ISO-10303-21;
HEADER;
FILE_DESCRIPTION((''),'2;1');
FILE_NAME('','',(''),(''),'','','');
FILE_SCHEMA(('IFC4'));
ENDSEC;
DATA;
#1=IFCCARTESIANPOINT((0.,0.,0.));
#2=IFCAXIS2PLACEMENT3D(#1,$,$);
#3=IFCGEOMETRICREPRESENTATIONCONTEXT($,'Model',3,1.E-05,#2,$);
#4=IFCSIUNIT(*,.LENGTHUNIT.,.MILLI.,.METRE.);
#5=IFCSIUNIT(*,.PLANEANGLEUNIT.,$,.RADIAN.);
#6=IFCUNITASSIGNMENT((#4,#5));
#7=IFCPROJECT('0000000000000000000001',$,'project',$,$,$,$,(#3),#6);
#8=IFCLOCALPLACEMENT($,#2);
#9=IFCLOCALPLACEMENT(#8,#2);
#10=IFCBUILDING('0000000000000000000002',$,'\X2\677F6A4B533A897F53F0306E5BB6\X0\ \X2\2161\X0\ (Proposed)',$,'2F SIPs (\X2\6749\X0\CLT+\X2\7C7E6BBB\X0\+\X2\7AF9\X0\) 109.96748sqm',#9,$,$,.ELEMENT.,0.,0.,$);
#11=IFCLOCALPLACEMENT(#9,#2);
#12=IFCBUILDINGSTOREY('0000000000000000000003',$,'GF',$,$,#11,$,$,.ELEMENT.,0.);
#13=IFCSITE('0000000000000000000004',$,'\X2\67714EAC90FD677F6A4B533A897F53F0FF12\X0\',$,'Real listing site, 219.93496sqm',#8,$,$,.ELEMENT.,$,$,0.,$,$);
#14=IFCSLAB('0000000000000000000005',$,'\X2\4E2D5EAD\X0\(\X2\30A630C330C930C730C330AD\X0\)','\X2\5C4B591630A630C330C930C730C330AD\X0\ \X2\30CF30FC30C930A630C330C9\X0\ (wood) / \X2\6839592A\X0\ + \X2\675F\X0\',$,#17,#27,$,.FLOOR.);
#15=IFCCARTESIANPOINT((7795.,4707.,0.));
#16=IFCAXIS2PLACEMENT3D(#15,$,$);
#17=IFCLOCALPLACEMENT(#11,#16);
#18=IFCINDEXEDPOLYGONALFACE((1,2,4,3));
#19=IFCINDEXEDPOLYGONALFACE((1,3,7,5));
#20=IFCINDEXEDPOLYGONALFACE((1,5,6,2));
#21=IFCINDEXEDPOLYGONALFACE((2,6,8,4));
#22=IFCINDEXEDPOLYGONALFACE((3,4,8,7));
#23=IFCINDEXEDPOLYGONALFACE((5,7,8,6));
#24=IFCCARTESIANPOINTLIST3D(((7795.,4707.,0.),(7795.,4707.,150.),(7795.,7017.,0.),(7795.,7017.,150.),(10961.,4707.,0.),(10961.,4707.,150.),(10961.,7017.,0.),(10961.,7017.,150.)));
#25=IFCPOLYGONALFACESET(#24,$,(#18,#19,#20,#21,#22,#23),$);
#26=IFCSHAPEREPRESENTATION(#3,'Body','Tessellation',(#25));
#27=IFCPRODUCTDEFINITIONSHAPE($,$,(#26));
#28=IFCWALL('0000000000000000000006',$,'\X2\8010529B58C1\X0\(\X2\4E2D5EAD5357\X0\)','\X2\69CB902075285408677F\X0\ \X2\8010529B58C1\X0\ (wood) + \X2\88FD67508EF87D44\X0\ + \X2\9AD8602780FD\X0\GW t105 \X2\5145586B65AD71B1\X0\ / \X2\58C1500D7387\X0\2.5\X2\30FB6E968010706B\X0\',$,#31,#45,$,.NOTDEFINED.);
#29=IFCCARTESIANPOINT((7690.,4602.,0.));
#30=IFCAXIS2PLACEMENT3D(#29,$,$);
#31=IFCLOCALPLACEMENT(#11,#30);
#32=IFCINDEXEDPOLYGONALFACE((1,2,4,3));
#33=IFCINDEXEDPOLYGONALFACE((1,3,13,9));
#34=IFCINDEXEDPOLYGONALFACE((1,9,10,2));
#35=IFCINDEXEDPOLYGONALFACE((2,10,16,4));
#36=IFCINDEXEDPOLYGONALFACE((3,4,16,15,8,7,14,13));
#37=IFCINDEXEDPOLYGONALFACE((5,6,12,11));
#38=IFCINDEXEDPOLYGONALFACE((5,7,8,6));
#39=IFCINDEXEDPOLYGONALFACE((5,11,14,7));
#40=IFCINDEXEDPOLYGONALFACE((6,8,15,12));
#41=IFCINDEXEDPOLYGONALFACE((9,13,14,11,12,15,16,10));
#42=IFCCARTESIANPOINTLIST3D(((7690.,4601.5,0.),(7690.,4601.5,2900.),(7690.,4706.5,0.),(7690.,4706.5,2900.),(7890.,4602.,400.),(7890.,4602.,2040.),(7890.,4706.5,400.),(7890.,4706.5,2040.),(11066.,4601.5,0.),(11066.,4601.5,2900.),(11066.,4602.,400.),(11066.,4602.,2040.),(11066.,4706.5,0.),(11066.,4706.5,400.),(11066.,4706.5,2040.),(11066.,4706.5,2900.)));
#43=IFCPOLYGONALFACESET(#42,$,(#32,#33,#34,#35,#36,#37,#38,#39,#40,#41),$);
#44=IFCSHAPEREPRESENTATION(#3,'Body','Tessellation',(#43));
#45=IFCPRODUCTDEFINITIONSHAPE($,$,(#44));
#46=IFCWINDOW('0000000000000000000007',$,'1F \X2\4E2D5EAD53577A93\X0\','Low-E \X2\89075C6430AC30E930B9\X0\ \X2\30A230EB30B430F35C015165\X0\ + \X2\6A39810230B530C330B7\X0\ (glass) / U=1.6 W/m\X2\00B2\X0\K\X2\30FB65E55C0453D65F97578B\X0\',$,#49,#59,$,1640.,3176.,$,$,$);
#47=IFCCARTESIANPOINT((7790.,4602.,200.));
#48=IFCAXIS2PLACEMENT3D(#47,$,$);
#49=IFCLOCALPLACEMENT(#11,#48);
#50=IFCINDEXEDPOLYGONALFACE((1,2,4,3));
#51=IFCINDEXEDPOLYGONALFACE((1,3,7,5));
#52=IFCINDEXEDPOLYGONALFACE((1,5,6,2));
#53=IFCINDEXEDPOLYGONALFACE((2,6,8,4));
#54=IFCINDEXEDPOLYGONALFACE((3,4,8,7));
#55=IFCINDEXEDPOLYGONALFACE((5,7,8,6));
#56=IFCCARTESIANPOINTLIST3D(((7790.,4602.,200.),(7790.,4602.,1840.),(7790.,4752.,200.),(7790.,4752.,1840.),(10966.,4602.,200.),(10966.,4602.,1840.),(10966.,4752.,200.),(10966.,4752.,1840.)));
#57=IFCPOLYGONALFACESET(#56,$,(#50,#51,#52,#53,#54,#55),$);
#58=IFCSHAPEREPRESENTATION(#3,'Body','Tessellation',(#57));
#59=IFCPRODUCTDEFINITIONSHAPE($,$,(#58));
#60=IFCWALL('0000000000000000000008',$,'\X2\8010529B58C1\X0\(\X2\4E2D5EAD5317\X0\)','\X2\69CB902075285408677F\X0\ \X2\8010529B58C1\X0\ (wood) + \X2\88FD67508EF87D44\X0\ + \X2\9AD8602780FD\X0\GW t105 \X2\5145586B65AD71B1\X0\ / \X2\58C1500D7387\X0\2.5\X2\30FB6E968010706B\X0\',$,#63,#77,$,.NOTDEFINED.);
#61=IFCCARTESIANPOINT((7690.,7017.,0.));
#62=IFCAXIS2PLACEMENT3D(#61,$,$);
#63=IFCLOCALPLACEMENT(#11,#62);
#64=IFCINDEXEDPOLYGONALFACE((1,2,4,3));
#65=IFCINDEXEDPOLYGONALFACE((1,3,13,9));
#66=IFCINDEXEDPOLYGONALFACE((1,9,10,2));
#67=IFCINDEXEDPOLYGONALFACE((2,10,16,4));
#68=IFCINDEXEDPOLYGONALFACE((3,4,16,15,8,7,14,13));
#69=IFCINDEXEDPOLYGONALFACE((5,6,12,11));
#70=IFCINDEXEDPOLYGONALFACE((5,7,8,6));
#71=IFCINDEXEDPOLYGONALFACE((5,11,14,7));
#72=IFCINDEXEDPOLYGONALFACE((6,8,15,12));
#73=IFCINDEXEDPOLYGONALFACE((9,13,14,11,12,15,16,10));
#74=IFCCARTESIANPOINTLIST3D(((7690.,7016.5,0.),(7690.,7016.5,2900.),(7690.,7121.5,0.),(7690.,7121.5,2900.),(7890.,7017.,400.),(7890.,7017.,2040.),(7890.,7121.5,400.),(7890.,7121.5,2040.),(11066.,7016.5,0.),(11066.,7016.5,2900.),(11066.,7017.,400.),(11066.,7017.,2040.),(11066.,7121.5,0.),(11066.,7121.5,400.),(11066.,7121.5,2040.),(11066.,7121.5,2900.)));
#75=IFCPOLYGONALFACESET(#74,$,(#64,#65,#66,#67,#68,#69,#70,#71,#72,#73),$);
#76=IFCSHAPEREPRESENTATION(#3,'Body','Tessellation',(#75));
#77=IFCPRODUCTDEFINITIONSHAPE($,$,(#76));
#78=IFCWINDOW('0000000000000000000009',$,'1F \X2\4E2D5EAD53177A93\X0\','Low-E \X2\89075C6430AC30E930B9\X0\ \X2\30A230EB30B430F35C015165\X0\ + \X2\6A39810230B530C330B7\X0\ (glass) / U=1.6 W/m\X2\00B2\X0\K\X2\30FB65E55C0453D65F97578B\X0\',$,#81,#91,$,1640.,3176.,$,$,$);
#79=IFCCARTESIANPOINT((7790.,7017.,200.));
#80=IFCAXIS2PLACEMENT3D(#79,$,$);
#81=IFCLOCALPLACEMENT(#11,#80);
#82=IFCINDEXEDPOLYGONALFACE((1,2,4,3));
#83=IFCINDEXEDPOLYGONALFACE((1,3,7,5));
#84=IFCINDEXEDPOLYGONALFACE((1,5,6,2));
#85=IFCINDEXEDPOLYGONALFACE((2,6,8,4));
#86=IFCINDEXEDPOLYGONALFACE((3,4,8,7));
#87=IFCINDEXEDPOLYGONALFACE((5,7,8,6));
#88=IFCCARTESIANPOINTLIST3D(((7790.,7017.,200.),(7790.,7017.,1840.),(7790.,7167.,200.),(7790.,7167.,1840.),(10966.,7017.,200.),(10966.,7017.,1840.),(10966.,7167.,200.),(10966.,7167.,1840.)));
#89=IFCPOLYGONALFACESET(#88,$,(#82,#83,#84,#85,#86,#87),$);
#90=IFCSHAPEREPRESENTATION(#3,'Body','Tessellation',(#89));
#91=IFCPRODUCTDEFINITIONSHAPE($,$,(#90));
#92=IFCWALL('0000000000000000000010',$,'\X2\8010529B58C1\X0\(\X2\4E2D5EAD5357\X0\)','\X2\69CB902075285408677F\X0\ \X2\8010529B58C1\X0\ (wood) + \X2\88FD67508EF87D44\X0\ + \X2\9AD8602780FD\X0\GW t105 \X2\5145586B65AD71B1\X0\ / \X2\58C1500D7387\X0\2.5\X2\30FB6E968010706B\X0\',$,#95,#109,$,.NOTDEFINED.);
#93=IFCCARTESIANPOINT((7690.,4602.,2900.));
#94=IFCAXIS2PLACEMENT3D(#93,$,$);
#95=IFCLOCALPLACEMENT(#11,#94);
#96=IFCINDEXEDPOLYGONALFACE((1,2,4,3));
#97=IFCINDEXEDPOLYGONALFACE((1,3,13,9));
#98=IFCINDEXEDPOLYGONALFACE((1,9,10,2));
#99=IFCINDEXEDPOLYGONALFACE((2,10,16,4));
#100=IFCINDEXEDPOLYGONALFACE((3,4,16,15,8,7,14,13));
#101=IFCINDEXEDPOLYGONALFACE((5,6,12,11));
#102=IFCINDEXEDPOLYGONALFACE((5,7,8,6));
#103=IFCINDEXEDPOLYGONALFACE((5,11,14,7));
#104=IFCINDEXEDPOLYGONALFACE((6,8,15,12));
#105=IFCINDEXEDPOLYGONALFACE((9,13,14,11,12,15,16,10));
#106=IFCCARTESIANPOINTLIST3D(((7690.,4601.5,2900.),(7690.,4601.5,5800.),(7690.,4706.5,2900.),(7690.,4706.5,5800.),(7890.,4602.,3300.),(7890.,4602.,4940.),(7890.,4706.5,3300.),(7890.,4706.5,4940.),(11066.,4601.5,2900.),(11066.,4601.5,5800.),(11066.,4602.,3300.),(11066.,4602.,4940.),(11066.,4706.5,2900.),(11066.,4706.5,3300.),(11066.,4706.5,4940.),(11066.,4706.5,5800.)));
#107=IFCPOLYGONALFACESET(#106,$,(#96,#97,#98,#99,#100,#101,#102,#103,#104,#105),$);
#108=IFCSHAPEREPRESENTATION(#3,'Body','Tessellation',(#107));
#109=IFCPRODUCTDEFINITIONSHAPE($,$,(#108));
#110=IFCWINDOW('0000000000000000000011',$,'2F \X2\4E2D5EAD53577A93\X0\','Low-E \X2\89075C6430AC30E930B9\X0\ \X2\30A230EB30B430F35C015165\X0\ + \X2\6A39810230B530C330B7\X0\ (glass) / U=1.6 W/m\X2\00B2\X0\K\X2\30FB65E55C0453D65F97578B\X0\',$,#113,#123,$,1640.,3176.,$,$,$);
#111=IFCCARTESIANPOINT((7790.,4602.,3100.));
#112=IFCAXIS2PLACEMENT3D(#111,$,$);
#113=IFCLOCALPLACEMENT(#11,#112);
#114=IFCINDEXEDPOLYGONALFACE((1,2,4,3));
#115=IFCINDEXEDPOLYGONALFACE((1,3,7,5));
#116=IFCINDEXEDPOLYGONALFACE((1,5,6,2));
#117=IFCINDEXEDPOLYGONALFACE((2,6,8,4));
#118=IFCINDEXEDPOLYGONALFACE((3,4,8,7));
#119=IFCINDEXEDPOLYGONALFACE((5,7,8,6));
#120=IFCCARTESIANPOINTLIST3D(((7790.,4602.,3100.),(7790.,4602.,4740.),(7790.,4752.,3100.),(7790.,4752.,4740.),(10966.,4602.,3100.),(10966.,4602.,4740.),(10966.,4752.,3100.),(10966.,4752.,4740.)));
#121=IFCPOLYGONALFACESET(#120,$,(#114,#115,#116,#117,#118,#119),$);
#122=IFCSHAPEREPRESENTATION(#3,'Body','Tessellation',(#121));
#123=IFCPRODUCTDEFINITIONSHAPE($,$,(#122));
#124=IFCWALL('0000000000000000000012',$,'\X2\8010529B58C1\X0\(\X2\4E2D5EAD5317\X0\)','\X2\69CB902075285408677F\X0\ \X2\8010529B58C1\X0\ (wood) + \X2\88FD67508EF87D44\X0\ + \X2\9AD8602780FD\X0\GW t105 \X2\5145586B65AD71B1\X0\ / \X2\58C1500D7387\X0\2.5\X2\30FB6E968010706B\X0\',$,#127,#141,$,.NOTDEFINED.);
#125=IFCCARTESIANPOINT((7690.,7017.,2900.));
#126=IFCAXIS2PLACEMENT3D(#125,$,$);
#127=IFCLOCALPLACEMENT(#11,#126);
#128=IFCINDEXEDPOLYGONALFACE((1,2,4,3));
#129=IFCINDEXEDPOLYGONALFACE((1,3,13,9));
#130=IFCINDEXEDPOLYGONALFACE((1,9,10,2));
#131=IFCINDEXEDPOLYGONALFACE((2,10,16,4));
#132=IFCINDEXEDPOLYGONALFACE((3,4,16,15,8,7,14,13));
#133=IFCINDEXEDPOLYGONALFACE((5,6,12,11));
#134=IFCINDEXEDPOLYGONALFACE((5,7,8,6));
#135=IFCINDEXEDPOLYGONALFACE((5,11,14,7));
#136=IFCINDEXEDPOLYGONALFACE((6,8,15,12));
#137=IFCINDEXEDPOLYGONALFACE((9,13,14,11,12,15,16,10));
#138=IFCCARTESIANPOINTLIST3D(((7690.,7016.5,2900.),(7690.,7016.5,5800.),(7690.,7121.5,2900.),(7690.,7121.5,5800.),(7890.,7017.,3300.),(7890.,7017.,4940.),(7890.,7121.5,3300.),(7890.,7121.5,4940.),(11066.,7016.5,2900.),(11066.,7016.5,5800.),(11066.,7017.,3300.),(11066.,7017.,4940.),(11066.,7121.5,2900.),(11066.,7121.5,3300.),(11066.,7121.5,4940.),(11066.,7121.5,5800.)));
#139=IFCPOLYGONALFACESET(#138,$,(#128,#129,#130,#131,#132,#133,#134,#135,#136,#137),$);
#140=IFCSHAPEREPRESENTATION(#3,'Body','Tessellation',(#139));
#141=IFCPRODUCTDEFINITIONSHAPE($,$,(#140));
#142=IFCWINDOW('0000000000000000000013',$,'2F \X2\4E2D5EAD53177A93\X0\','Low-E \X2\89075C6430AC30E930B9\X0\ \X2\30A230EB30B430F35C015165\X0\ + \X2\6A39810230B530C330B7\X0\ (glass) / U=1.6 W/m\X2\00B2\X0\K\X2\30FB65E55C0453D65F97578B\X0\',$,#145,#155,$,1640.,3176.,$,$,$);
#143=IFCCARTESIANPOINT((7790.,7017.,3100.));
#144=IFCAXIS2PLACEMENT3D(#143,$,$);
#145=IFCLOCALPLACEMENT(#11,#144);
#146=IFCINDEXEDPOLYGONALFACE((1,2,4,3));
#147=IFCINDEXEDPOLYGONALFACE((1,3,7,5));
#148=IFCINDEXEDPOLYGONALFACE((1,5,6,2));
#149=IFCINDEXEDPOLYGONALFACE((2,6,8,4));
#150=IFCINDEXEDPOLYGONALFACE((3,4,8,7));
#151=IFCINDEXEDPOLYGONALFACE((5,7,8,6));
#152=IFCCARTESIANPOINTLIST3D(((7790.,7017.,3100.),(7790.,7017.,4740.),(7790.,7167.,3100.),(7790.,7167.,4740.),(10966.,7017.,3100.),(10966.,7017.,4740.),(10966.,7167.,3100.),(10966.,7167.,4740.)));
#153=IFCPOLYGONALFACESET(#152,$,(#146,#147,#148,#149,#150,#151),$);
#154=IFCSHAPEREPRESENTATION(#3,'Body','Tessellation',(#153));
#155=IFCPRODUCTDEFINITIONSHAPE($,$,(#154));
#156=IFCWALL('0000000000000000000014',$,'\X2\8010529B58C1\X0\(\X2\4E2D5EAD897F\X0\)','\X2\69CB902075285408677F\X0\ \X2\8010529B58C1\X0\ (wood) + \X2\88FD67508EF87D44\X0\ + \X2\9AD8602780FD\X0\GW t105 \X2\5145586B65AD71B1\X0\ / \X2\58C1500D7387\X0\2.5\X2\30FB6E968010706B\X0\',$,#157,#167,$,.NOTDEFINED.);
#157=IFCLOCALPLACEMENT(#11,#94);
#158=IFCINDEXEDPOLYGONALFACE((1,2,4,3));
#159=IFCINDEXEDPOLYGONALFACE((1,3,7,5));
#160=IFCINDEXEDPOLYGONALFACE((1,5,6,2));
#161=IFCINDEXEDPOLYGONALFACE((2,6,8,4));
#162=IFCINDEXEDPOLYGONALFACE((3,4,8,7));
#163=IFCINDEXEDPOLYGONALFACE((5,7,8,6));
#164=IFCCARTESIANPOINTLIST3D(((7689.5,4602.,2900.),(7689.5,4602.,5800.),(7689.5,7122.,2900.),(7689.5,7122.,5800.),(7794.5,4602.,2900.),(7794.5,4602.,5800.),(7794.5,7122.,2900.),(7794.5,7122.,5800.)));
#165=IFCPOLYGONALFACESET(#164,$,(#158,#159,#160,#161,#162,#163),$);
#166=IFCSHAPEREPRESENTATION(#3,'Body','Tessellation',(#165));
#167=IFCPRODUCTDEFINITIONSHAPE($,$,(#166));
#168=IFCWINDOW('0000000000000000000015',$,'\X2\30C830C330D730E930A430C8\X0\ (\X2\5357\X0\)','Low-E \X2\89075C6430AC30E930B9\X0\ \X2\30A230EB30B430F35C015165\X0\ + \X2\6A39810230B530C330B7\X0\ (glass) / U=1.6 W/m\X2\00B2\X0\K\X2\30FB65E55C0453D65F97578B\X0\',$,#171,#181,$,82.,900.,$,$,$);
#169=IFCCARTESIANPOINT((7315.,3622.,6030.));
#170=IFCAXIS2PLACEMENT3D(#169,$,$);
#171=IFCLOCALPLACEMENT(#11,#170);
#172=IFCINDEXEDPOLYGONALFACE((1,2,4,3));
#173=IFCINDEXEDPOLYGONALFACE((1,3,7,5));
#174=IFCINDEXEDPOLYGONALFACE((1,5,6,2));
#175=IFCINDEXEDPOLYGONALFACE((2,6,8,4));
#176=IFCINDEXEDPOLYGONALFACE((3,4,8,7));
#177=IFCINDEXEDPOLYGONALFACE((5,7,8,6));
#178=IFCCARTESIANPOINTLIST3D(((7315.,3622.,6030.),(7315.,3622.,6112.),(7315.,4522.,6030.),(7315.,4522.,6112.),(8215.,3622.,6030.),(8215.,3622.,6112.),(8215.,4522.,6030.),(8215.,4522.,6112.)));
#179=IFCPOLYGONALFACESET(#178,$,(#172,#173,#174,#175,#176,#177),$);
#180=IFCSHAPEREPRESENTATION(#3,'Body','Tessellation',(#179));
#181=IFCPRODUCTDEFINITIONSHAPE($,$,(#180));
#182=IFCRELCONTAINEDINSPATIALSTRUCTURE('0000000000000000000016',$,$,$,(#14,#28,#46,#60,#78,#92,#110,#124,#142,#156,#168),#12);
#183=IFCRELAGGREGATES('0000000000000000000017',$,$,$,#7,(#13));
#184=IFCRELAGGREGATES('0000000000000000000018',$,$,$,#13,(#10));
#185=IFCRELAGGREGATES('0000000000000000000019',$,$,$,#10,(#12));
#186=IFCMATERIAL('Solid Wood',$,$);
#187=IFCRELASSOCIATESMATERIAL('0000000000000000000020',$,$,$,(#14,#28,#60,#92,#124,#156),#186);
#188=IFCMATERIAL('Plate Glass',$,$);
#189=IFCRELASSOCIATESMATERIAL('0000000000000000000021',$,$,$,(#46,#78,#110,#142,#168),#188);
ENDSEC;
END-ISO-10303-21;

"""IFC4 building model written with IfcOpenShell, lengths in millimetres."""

from ifc_helpers import new_model, si_unit, frame, frame_2d, origin, place, context, project, spatial, rectangle, extrude, material, element, fill, save


model = new_model("IFC4")

# Units and contexts
model_context = context("Model", 3, precision=1e-05, world=origin())
ifc_project = project(units=[si_unit("LENGTHUNIT", "METRE", prefix="MILLI"), si_unit("PLANEANGLEUNIT", "RADIAN")], contexts=[model_context])

# Site, building, storey
site_placement = place(None, origin())
site = spatial("IfcSite", under=ifc_project, at=site_placement, Name="東京都板橋区西台２", ObjectType="Real listing site, 219.93496sqm", CompositionType="ELEMENT", RefElevation=0.0)
building_placement = place(site_placement, origin())
building = spatial("IfcBuilding", under=site, at=building_placement, Name="板橋区西台の家 Ⅱ (Proposed)", ObjectType="2F SIPs (杉CLT+籾殻+竹) 109.96748sqm", CompositionType="ELEMENT", ElevationOfRefHeight=0.0, ElevationOfTerrain=0.0)
storey_placement = place(building_placement, origin())
storey = spatial("IfcBuildingStorey", under=building, at=storey_placement, Name="GF", CompositionType="ELEMENT", Elevation=0.0)

# Slab
ifc_material_1 = material(Name="Solid Wood")
slab_placement = place(storey_placement, frame((7795.0, 4707.0, 0.0)))
element("IfcSlab", 1, at=slab_placement, inside=storey, material=ifc_material_1, Name="中庭(ウッドデッキ)", Description="屋外ウッドデッキ ハードウッド (wood) / 根太 + 束", PredefinedType="FLOOR", context=model_context, shape_type="SweptSolid", body=[
    extrude(rectangle(XDim=3166.0, YDim=2310.0, at=frame_2d((1583.0, 1155.0))), frame((7795.0, 4707.0, 0.0)), (0.0, 0.0, 1.0), 150.0),
])

# Walls, openings, windows
wall_1_placement = place(storey_placement, frame((7690.0, 4602.0, 0.0)))
wall_1 = element("IfcWall", 2, at=wall_1_placement, inside=storey, material=ifc_material_1, Name="耐力壁(中庭南)", Description="構造用合板 耐力壁 (wood) + 製材軸組 + 高性能GW t105 充填断熱 / 壁倍率2.5・準耐火", PredefinedType="NOTDEFINED", context=model_context, shape_type="SweptSolid", body=[
    extrude(rectangle(XDim=3376.0, YDim=105.0, at=frame_2d((1688.0, 52.0))), frame((7690.0, 4602.0, 0.0)), (0.0, 0.0, 1.0), 2900.0),
])
opening_1_placement = place(storey_placement, frame((7790.0, 4602.0, 200.0)))
opening_1 = element("IfcOpeningElement", 3, at=opening_1_placement, cuts=wall_1, PredefinedType="NOTDEFINED", context=model_context, shape_type="SweptSolid", body=[
    extrude(rectangle(XDim=3176.0, YDim=150.0, at=frame_2d((1588.0, 75.0))), frame((7790.0, 4602.0, 200.0)), (0.0, 0.0, 1.0), 1640.0),
])
ifc_material_2 = material(Name="Plate Glass")
window_1_placement = place(storey_placement, frame((7790.0, 4602.0, 200.0)))
window_1 = element("IfcWindow", 4, at=window_1_placement, inside=storey, material=ifc_material_2, Name="1F 中庭南窓", Description="Low-E 複層ガラス アルゴン封入 + 樹脂サッシ (glass) / U=1.6 W/m²K・日射取得型", OverallHeight=1640.0, OverallWidth=3176.0, context=model_context, shape_type="SweptSolid", body=[
    extrude(rectangle(XDim=3176.0, YDim=150.0, at=frame_2d((1588.0, 75.0))), frame((7790.0, 4602.0, 200.0)), (0.0, 0.0, 1.0), 1640.0),
])
fill(opening_1, window_1)
wall_2_placement = place(storey_placement, frame((7690.0, 7017.0, 0.0)))
wall_2 = element("IfcWall", 5, at=wall_2_placement, inside=storey, material=ifc_material_1, Name="耐力壁(中庭北)", Description="構造用合板 耐力壁 (wood) + 製材軸組 + 高性能GW t105 充填断熱 / 壁倍率2.5・準耐火", PredefinedType="NOTDEFINED", context=model_context, shape_type="SweptSolid", body=[
    extrude(rectangle(XDim=3376.0, YDim=105.0, at=frame_2d((1688.0, 52.0))), frame((7690.0, 7017.0, 0.0)), (0.0, 0.0, 1.0), 2900.0),
])
opening_2_placement = place(storey_placement, frame((7790.0, 7017.0, 200.0)))
opening_2 = element("IfcOpeningElement", 6, at=opening_2_placement, cuts=wall_2, PredefinedType="NOTDEFINED", context=model_context, shape_type="SweptSolid", body=[
    extrude(rectangle(XDim=3176.0, YDim=150.0, at=frame_2d((1588.0, 75.0))), frame((7790.0, 7017.0, 200.0)), (0.0, 0.0, 1.0), 1640.0),
])
window_2_placement = place(storey_placement, frame((7790.0, 7017.0, 200.0)))
window_2 = element("IfcWindow", 7, at=window_2_placement, inside=storey, material=ifc_material_2, Name="1F 中庭北窓", Description="Low-E 複層ガラス アルゴン封入 + 樹脂サッシ (glass) / U=1.6 W/m²K・日射取得型", OverallHeight=1640.0, OverallWidth=3176.0, context=model_context, shape_type="SweptSolid", body=[
    extrude(rectangle(XDim=3176.0, YDim=150.0, at=frame_2d((1588.0, 75.0))), frame((7790.0, 7017.0, 200.0)), (0.0, 0.0, 1.0), 1640.0),
])
fill(opening_2, window_2)

# Walls, openings, windows
wall_3_placement = place(storey_placement, frame((7690.0, 4602.0, 2900.0)))
wall_3 = element("IfcWall", 8, at=wall_3_placement, inside=storey, material=ifc_material_1, Name="耐力壁(中庭南)", Description="構造用合板 耐力壁 (wood) + 製材軸組 + 高性能GW t105 充填断熱 / 壁倍率2.5・準耐火", PredefinedType="NOTDEFINED", context=model_context, shape_type="SweptSolid", body=[
    extrude(rectangle(XDim=3376.0, YDim=105.0, at=frame_2d((1688.0, 52.0))), frame((7690.0, 4602.0, 2900.0)), (0.0, 0.0, 1.0), 2900.0),
])
opening_3_placement = place(storey_placement, frame((7790.0, 4602.0, 3100.0)))
opening_3 = element("IfcOpeningElement", 9, at=opening_3_placement, cuts=wall_3, PredefinedType="NOTDEFINED", context=model_context, shape_type="SweptSolid", body=[
    extrude(rectangle(XDim=3176.0, YDim=150.0, at=frame_2d((1588.0, 75.0))), frame((7790.0, 4602.0, 3100.0)), (0.0, 0.0, 1.0), 1640.0),
])
window_3_placement = place(storey_placement, frame((7790.0, 4602.0, 3100.0)))
window_3 = element("IfcWindow", 10, at=window_3_placement, inside=storey, material=ifc_material_2, Name="2F 中庭南窓", Description="Low-E 複層ガラス アルゴン封入 + 樹脂サッシ (glass) / U=1.6 W/m²K・日射取得型", OverallHeight=1640.0, OverallWidth=3176.0, context=model_context, shape_type="SweptSolid", body=[
    extrude(rectangle(XDim=3176.0, YDim=150.0, at=frame_2d((1588.0, 75.0))), frame((7790.0, 4602.0, 3100.0)), (0.0, 0.0, 1.0), 1640.0),
])
fill(opening_3, window_3)
wall_4_placement = place(storey_placement, frame((7690.0, 7017.0, 2900.0)))
wall_4 = element("IfcWall", 11, at=wall_4_placement, inside=storey, material=ifc_material_1, Name="耐力壁(中庭北)", Description="構造用合板 耐力壁 (wood) + 製材軸組 + 高性能GW t105 充填断熱 / 壁倍率2.5・準耐火", PredefinedType="NOTDEFINED", context=model_context, shape_type="SweptSolid", body=[
    extrude(rectangle(XDim=3376.0, YDim=105.0, at=frame_2d((1688.0, 52.0))), frame((7690.0, 7017.0, 2900.0)), (0.0, 0.0, 1.0), 2900.0),
])
opening_4_placement = place(storey_placement, frame((7790.0, 7017.0, 3100.0)))
opening_4 = element("IfcOpeningElement", 12, at=opening_4_placement, cuts=wall_4, PredefinedType="NOTDEFINED", context=model_context, shape_type="SweptSolid", body=[
    extrude(rectangle(XDim=3176.0, YDim=150.0, at=frame_2d((1588.0, 75.0))), frame((7790.0, 7017.0, 3100.0)), (0.0, 0.0, 1.0), 1640.0),
])
window_4_placement = place(storey_placement, frame((7790.0, 7017.0, 3100.0)))
window_4 = element("IfcWindow", 13, at=window_4_placement, inside=storey, material=ifc_material_2, Name="2F 中庭北窓", Description="Low-E 複層ガラス アルゴン封入 + 樹脂サッシ (glass) / U=1.6 W/m²K・日射取得型", OverallHeight=1640.0, OverallWidth=3176.0, context=model_context, shape_type="SweptSolid", body=[
    extrude(rectangle(XDim=3176.0, YDim=150.0, at=frame_2d((1588.0, 75.0))), frame((7790.0, 7017.0, 3100.0)), (0.0, 0.0, 1.0), 1640.0),
])
fill(opening_4, window_4)

# Wall
wall_5_placement = place(storey_placement, frame((7690.0, 4602.0, 2900.0)))
element("IfcWall", 14, at=wall_5_placement, inside=storey, material=ifc_material_1, Name="耐力壁(中庭西)", Description="構造用合板 耐力壁 (wood) + 製材軸組 + 高性能GW t105 充填断熱 / 壁倍率2.5・準耐火", PredefinedType="NOTDEFINED", context=model_context, shape_type="SweptSolid", body=[
    extrude(rectangle(XDim=105.0, YDim=2520.0, at=frame_2d((52.0, 1260.0))), frame((7690.0, 4602.0, 2900.0)), (0.0, 0.0, 1.0), 2900.0),
])

# Window
window_5_placement = place(storey_placement, frame((7315.0, 3622.0, 6030.0)))
element("IfcWindow", 15, at=window_5_placement, inside=storey, material=ifc_material_2, Name="トップライト (南)", Description="Low-E 複層ガラス アルゴン封入 + 樹脂サッシ (glass) / U=1.6 W/m²K・日射取得型", OverallHeight=82.0, OverallWidth=900.0, context=model_context, shape_type="SweptSolid", body=[
    extrude(rectangle(XDim=900.0, YDim=900.0, at=frame_2d((450.0, 450.0))), frame((7315.0, 3622.0, 6030.0)), (0.0, 0.0, 1.0), 82.0),
])

save(model, "model.ifc")
